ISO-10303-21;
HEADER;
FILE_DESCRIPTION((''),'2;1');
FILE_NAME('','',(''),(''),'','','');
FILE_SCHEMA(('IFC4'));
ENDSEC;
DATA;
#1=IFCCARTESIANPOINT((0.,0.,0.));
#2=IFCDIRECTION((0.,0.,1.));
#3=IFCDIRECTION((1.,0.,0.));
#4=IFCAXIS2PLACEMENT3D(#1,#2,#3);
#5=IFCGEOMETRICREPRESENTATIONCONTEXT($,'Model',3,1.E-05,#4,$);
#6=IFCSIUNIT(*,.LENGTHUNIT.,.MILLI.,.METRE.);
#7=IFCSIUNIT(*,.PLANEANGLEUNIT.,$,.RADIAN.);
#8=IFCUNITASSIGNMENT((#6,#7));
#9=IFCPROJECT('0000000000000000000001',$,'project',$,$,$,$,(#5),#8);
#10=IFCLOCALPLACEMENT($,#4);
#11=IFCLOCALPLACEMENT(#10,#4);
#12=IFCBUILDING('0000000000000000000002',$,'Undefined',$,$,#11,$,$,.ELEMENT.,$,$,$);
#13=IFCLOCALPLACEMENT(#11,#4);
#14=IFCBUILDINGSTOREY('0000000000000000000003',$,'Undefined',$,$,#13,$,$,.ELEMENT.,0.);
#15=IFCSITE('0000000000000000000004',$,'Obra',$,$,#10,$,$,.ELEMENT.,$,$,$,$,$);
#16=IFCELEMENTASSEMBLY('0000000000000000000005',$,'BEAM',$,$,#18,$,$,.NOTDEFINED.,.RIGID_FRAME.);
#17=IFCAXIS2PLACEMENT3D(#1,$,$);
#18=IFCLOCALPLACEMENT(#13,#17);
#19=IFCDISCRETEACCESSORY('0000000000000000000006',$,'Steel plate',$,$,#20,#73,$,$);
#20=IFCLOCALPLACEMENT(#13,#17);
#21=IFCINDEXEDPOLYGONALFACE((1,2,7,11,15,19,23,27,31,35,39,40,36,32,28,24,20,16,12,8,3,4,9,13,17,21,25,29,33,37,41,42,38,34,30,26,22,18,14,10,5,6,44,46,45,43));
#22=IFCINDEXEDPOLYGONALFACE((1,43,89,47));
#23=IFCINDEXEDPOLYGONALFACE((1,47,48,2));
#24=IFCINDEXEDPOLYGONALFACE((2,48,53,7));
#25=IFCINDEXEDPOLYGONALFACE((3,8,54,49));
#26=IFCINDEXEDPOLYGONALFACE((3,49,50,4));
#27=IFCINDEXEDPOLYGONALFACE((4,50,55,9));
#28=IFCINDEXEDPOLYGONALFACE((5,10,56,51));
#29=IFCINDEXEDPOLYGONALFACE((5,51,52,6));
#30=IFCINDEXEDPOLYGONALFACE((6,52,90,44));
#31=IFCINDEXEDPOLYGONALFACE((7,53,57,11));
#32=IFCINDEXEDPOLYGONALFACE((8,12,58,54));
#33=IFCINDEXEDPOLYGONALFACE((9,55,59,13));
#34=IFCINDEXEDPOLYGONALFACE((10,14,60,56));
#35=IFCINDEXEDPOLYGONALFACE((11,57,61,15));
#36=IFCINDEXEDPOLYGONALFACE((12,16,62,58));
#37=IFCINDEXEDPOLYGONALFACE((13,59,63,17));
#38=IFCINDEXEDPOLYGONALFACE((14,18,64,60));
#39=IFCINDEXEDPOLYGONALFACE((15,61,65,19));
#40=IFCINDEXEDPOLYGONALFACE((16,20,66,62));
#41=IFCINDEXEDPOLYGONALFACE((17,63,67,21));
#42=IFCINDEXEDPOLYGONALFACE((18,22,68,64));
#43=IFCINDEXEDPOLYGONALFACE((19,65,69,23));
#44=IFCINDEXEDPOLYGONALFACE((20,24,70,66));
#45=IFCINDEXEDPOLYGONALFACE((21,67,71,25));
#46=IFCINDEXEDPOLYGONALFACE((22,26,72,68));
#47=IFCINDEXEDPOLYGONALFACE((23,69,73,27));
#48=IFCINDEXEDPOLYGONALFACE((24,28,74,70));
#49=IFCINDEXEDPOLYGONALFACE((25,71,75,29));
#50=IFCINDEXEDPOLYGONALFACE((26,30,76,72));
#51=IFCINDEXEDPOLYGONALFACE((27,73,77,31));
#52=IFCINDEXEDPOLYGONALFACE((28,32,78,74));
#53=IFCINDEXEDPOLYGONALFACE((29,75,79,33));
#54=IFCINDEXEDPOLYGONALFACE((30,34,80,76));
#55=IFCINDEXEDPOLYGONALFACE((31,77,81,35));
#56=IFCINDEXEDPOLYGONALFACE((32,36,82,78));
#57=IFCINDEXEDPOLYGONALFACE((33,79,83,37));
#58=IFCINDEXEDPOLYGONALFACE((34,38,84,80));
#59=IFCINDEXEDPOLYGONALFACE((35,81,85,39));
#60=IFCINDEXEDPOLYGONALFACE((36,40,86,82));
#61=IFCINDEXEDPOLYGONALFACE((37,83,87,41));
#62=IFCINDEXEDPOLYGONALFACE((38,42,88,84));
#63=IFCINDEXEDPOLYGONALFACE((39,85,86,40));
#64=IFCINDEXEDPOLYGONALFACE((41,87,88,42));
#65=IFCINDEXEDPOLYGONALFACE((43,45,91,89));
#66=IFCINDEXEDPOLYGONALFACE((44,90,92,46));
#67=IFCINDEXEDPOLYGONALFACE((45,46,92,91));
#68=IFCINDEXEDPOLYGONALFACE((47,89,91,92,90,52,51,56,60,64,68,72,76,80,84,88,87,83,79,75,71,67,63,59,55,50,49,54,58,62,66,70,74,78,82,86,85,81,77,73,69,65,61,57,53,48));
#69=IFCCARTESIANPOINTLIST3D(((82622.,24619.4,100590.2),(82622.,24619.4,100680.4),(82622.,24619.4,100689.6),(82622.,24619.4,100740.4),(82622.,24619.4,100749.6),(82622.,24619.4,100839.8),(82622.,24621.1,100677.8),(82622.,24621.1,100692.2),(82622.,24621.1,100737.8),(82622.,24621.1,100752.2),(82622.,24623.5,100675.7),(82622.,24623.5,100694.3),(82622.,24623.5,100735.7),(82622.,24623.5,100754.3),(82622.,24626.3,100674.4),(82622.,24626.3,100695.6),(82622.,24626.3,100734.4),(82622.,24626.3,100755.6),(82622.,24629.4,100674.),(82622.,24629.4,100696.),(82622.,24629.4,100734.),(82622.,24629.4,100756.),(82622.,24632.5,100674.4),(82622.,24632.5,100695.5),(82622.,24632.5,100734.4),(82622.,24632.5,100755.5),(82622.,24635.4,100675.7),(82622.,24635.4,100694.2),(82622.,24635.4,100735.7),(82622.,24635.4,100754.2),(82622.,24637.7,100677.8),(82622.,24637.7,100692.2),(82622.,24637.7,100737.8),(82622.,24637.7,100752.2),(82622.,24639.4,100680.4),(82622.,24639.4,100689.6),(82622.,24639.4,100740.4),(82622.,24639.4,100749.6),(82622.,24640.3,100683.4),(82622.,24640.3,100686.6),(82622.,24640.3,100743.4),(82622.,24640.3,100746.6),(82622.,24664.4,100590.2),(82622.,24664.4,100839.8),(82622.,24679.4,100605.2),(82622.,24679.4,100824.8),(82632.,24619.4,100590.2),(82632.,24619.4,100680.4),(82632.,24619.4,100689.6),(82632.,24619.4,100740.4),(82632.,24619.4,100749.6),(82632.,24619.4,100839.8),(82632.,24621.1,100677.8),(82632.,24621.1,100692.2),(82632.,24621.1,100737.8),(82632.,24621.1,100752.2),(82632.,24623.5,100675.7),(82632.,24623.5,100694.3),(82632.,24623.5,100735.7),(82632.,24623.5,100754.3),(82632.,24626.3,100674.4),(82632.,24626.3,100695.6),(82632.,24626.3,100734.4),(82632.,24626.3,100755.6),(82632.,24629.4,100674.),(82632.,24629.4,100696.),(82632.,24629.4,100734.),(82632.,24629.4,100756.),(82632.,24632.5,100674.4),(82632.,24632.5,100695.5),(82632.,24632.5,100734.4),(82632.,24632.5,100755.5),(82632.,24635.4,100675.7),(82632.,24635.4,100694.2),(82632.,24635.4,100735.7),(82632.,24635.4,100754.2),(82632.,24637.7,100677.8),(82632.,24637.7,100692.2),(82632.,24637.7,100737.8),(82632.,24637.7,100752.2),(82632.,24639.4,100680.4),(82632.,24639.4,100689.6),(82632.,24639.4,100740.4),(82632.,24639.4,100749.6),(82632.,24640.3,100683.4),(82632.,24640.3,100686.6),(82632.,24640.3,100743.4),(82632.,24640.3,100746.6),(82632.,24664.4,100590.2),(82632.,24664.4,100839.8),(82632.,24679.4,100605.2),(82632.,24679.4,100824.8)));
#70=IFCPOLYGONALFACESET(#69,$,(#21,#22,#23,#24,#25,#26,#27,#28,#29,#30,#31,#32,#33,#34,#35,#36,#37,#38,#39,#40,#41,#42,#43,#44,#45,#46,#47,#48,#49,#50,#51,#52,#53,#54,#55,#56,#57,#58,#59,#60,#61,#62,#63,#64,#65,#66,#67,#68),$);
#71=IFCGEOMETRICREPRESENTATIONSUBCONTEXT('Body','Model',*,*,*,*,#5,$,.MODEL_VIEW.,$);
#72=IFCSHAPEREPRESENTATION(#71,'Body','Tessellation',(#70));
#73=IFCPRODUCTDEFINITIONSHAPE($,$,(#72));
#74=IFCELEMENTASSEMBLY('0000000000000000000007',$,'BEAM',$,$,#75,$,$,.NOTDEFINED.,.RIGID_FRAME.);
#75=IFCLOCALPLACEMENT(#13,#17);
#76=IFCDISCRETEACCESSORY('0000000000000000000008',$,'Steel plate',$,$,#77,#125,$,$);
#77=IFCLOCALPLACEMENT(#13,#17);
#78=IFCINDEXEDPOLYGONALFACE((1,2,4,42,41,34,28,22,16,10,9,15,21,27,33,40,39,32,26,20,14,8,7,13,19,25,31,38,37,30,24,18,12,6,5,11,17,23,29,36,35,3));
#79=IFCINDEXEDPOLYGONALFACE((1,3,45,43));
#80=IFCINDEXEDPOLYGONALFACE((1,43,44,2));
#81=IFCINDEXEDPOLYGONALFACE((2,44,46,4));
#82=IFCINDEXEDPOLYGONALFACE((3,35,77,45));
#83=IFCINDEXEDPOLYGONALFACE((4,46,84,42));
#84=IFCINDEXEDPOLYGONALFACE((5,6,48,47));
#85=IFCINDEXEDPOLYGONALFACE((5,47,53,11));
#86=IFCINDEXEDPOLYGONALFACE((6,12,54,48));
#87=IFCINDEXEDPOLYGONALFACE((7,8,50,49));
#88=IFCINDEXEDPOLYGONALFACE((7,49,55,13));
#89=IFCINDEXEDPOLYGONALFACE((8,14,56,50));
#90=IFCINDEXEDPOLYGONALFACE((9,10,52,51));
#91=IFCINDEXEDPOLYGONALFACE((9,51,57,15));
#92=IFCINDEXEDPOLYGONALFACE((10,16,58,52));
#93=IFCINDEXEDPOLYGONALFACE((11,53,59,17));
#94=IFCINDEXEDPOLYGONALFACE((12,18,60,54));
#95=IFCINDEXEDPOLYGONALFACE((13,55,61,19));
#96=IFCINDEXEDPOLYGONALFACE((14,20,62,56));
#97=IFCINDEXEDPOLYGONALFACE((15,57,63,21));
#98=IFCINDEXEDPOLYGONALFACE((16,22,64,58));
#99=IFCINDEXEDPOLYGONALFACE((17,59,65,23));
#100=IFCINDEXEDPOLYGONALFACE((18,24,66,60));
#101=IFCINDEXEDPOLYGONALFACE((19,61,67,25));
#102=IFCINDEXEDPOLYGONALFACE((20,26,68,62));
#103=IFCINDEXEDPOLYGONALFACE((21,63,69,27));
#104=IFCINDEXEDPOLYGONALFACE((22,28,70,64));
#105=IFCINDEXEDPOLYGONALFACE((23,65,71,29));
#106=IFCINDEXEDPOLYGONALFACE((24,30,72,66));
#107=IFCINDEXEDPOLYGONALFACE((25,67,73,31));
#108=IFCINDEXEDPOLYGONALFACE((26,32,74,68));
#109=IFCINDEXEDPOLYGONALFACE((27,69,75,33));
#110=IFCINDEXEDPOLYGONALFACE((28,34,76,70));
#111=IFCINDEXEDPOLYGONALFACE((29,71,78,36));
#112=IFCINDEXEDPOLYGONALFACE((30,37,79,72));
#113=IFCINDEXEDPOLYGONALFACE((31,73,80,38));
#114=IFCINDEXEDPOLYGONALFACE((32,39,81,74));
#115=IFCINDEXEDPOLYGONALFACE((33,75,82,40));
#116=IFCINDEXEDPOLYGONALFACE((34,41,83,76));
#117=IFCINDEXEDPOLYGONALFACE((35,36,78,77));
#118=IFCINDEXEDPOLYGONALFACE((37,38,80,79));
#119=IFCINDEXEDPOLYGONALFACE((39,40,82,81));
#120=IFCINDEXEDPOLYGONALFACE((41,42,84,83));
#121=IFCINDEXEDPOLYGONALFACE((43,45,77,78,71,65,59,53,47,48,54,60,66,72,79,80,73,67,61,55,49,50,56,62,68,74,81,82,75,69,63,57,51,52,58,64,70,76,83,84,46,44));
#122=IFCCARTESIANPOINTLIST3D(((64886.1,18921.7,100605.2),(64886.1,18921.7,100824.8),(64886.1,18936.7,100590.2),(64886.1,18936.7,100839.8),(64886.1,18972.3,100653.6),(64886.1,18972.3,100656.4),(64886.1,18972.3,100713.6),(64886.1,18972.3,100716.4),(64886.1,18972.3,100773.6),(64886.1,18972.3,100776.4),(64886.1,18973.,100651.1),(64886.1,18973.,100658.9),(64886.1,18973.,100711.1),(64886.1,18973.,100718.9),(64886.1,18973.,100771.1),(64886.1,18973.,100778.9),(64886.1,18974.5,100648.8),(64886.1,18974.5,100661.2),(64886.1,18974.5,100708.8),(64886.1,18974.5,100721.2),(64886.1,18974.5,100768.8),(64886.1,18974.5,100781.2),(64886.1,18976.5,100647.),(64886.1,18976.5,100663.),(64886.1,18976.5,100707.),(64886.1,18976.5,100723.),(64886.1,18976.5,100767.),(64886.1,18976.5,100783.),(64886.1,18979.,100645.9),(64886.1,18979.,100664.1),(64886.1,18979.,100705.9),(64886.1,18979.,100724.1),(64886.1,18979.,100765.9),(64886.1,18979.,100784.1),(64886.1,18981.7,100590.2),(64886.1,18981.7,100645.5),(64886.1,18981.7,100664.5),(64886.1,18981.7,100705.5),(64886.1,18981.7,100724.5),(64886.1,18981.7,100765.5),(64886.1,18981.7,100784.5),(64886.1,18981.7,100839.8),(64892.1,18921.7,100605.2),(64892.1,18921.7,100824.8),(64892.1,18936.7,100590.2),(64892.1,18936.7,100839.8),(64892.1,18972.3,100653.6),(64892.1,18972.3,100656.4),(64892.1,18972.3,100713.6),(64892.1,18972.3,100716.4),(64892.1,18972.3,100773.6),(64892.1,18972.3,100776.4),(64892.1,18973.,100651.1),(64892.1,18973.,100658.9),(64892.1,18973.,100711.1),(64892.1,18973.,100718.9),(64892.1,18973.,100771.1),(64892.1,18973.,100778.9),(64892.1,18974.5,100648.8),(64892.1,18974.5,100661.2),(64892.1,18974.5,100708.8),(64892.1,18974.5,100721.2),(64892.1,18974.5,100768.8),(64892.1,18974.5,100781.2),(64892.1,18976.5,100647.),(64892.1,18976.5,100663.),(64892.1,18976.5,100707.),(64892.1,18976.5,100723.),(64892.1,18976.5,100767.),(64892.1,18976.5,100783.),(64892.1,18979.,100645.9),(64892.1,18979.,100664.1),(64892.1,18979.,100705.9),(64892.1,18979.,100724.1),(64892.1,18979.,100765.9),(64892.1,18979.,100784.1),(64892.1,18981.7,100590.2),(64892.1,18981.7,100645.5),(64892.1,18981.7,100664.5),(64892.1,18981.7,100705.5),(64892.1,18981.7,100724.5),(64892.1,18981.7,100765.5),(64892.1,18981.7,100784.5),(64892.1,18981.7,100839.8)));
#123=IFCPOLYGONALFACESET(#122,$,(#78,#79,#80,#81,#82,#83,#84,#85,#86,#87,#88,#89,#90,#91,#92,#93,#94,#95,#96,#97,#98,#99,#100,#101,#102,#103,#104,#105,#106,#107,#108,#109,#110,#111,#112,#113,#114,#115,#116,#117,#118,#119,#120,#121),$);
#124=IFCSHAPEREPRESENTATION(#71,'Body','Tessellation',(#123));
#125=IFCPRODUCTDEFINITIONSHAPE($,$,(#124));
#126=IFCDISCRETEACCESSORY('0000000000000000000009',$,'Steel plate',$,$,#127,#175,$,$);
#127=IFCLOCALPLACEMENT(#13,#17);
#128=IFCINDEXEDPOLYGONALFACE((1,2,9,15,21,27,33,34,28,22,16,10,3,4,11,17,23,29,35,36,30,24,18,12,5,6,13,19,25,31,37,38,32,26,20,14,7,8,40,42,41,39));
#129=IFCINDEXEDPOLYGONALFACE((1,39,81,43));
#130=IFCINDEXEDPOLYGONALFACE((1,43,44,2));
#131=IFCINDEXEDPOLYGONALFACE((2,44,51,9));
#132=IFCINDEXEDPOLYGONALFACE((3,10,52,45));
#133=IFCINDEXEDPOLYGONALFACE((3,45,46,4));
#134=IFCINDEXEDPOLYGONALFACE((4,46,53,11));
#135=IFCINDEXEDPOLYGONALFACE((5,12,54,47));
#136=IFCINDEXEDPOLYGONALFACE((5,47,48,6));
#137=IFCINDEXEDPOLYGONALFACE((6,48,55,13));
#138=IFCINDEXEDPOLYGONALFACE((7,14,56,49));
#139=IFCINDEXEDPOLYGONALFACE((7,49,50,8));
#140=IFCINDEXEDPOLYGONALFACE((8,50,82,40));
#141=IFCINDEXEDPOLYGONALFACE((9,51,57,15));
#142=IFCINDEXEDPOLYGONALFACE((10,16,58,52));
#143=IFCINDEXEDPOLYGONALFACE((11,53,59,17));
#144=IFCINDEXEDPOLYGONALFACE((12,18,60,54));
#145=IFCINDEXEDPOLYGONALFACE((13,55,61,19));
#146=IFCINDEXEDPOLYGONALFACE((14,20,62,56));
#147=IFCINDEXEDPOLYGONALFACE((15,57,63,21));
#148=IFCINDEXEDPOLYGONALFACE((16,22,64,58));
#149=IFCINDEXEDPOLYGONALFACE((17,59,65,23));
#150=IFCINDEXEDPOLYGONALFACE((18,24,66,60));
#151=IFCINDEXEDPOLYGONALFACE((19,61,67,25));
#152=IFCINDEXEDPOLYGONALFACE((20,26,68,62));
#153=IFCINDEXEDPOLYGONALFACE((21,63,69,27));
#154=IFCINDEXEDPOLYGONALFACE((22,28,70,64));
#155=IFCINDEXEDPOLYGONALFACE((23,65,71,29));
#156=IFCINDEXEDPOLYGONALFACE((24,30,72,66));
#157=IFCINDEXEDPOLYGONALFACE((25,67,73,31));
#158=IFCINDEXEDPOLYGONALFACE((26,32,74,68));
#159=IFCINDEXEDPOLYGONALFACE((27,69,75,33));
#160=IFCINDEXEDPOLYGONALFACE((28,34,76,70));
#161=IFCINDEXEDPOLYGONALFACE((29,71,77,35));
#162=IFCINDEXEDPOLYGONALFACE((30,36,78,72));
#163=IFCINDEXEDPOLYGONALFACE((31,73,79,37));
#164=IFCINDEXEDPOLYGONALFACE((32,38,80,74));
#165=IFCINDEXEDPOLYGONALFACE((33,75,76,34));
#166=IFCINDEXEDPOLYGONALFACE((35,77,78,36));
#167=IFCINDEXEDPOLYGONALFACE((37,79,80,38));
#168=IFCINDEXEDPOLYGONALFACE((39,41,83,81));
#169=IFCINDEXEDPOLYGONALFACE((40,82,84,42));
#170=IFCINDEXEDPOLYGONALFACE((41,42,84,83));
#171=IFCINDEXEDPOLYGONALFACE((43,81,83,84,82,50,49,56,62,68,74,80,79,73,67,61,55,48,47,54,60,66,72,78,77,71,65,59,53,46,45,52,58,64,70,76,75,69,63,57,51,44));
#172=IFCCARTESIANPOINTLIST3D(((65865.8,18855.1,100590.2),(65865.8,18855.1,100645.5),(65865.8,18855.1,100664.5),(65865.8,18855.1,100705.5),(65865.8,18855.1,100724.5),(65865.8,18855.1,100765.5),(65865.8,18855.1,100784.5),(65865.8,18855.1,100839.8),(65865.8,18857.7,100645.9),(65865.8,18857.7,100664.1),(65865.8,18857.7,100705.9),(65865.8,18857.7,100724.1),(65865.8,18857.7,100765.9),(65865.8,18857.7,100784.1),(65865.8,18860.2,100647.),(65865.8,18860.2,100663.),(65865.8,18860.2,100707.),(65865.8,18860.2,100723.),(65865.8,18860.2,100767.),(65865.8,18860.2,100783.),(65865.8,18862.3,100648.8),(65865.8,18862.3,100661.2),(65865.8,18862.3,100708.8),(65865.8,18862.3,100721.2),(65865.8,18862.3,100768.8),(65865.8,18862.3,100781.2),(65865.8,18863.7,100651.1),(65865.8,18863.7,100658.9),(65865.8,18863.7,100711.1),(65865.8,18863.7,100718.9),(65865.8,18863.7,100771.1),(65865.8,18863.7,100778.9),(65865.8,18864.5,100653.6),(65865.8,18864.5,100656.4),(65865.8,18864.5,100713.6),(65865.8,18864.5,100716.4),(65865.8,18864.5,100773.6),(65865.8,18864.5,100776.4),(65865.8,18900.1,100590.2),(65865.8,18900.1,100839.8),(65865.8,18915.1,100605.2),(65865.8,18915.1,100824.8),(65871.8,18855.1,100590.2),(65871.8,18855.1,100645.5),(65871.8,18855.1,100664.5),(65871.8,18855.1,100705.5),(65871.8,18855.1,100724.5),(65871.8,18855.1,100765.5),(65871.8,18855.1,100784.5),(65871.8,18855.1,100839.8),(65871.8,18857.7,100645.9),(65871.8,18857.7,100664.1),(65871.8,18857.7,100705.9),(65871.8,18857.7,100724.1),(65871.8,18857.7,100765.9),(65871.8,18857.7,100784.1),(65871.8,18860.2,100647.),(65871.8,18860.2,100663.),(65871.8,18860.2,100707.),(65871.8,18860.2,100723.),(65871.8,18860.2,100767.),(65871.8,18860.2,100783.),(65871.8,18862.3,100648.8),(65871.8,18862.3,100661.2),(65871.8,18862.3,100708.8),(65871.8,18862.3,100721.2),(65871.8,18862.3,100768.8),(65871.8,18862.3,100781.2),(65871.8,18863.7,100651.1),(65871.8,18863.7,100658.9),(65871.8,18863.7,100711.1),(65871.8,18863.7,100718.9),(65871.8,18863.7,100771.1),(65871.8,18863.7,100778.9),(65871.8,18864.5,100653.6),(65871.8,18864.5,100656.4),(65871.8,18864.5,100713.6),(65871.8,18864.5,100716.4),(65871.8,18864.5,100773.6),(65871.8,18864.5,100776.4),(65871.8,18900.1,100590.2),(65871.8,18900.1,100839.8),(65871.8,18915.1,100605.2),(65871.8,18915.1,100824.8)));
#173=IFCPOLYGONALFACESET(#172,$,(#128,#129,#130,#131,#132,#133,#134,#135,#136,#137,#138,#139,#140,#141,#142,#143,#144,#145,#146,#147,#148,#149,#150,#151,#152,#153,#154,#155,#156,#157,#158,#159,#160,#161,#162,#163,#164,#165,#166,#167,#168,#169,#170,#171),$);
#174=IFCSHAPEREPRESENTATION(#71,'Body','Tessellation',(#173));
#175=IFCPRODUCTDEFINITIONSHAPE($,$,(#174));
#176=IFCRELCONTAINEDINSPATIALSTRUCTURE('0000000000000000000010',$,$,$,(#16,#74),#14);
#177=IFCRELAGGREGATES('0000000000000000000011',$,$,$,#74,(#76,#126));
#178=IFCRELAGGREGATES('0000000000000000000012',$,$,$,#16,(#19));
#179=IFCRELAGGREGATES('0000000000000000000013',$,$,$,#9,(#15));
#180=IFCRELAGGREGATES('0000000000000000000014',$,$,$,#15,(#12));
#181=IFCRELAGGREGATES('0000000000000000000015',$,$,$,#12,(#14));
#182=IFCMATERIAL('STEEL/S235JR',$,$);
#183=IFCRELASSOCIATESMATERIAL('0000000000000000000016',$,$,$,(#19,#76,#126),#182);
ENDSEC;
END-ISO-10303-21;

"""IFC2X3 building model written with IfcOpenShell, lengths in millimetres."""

from ifc_helpers import new_model, si_unit, frame, origin_with_axes, origin_2d_with_axis, place, context, subcontext, project, spatial, polyline, circle, outline, extrude, source, transform, mapped, material, element, aggregate, save


model = new_model("IFC2X3")

# Units and contexts
model_context = context("Model", 3, precision=1e-05, world=origin_with_axes())
body_context = subcontext(model_context, "Body", "Model", "MODEL_VIEW")
ifc_project = project(units=[si_unit("LENGTHUNIT", "METRE", prefix="MILLI"), si_unit("PLANEANGLEUNIT", "RADIAN")], contexts=[model_context])

# Site, building, storey
site_placement = place(None, origin_with_axes())
site = spatial("IfcSite", under=ifc_project, at=site_placement, Name="Obra", CompositionType="ELEMENT")
building_placement = place(site_placement, origin_with_axes())
building = spatial("IfcBuilding", under=site, at=building_placement, Name="Undefined", CompositionType="ELEMENT")
storey_placement = place(building_placement, origin_with_axes())
storey = spatial("IfcBuildingStorey", under=building, at=storey_placement, Name="Undefined", CompositionType="ELEMENT", Elevation=0.0)

# Element assembly, discrete accessory, opening
assembly_1_placement = place(storey_placement, origin_with_axes())
assembly_1 = element("IfcElementAssembly", 1, at=assembly_1_placement, inside=storey, Name="BEAM", AssemblyPlace="NOTDEFINED", PredefinedType="RIGID_FRAME")
ifc_material = material(Name="STEEL/S235JR")
discrete_accessory_1_placement = place(assembly_1_placement, frame((82627.0, 24619.4, 100590.2), z_axis=(1.0, 0.000001, 0.0), x_axis=(-0.000002, 1.0, 0.0)))
discrete_accessory_1 = element("IfcDiscreteAccessory", 2, at=discrete_accessory_1_placement, material=ifc_material, Name="Steel plate", context=body_context, shape_type="SweptSolid", body=[
    extrude(outline(polyline([(0.0, 0.0), (45.0, 0.0), (60.0, 15.0), (60.0, 234.6), (45.0, 249.6), (0.0, 249.6), (0.0, 0.0)])), frame((0.0, 0.0, -5.0), z_axis=(0.0, 0.0, 1.0), x_axis=(1.0, 0.0, 0.0)), (0.0, 0.0, 1.0), 10.0),
])
shared_shape_1 = source(origin_with_axes(), body_context, "Body", "SweptSolid", [
    extrude(circle(Radius=11.0, at=origin_2d_with_axis()), frame((0.0, -13.4, 0.0), z_axis=(0.0, 1.0, 0.0), x_axis=(1.0, 0.0, 0.0)), (0.0, 0.0, 1.0), 10.2),
])
opening_1_placement = place(assembly_1_placement, frame((82635.3, 24669.4, 100850.0), z_axis=(0.000002, -1.0, 0.0), x_axis=(0.0, 0.0, -1.0)))
element("IfcOpeningElement", 3, at=opening_1_placement, cuts=discrete_accessory_1, ObjectType="Opening", context=body_context, shape_type="MappedRepresentation", body=[
    mapped(shared_shape_1, transform((105.0, 0.0, 40.0))),
    mapped(shared_shape_1, transform((165.0, 0.0, 40.0))),
])

# Element assembly, discrete accessories, openings
assembly_2_placement = place(storey_placement, origin_with_axes())
assembly_2 = element("IfcElementAssembly", 4, at=assembly_2_placement, inside=storey, Name="BEAM", AssemblyPlace="NOTDEFINED", PredefinedType="RIGID_FRAME")
discrete_accessory_2_placement = place(assembly_2_placement, frame((64889.1, 18981.7, 100590.2), z_axis=(-1.0, -0.000002, 0.0), x_axis=(0.000002, -1.0, 0.0)))
discrete_accessory_2 = element("IfcDiscreteAccessory", 5, at=discrete_accessory_2_placement, material=ifc_material, Name="Steel plate", context=body_context, shape_type="SweptSolid", body=[
    extrude(outline(polyline([(0.0, 0.0), (45.0, 0.0), (60.0, 15.0), (60.0, 234.6), (45.0, 249.6), (0.0, 249.6), (0.0, 0.0)])), frame((0.0, 0.0, -3.0), z_axis=(0.0, 0.0, 1.0), x_axis=(1.0, 0.0, 0.0)), (0.0, 0.0, 1.0), 6.0),
])
shared_shape_2 = source(origin_with_axes(), body_context, "Body", "SweptSolid", [
    extrude(circle(Radius=9.5, at=origin_2d_with_axis()), frame((0.0, -9.4, 0.0), z_axis=(0.0, 1.0, 0.0), x_axis=(1.0, 0.0, 0.0)), (0.0, 0.0, 1.0), 6.2),
])
opening_2_placement = place(assembly_2_placement, frame((64882.8, 18931.7, 100850.0), z_axis=(-0.000002, 1.0, 0.0), x_axis=(0.0, 0.0, -1.0)))
element("IfcOpeningElement", 6, at=opening_2_placement, cuts=discrete_accessory_2, ObjectType="Opening", context=body_context, shape_type="MappedRepresentation", body=[
    mapped(shared_shape_2, transform((75.0, 0.0, 50.0))),
    mapped(shared_shape_2, transform((135.0, 0.0, 50.0))),
    mapped(shared_shape_2, transform((195.0, 0.0, 50.0))),
])
discrete_accessory_3_placement = place(assembly_2_placement, frame((65868.8, 18855.1, 100590.2), z_axis=(1.0, 0.000001, 0.0), x_axis=(-0.000002, 1.0, 0.0)))
discrete_accessory_3 = element("IfcDiscreteAccessory", 7, at=discrete_accessory_3_placement, material=ifc_material, Name="Steel plate", context=body_context, shape_type="SweptSolid", body=[
    extrude(outline(polyline([(0.0, 0.0), (45.0, 0.0), (60.0, 15.0), (60.0, 234.6), (45.0, 249.6), (0.0, 249.6), (0.0, 0.0)])), frame((0.0, 0.0, -3.0), z_axis=(0.0, 0.0, 1.0), x_axis=(1.0, 0.0, 0.0)), (0.0, 0.0, 1.0), 6.0),
])
opening_3_placement = place(assembly_2_placement, frame((65875.1, 18905.1, 100850.0), z_axis=(0.000002, -1.0, 0.0), x_axis=(0.0, 0.0, -1.0)))
element("IfcOpeningElement", 8, at=opening_3_placement, cuts=discrete_accessory_3, ObjectType="Opening", context=body_context, shape_type="MappedRepresentation", body=[
    mapped(shared_shape_2, transform((75.0, 0.0, 50.0))),
    mapped(shared_shape_2, transform((135.0, 0.0, 50.0))),
    mapped(shared_shape_2, transform((195.0, 0.0, 50.0))),
])
aggregate(assembly_2, [discrete_accessory_2, discrete_accessory_3])

aggregate(assembly_1, [discrete_accessory_1])

save(model, "model.ifc")
